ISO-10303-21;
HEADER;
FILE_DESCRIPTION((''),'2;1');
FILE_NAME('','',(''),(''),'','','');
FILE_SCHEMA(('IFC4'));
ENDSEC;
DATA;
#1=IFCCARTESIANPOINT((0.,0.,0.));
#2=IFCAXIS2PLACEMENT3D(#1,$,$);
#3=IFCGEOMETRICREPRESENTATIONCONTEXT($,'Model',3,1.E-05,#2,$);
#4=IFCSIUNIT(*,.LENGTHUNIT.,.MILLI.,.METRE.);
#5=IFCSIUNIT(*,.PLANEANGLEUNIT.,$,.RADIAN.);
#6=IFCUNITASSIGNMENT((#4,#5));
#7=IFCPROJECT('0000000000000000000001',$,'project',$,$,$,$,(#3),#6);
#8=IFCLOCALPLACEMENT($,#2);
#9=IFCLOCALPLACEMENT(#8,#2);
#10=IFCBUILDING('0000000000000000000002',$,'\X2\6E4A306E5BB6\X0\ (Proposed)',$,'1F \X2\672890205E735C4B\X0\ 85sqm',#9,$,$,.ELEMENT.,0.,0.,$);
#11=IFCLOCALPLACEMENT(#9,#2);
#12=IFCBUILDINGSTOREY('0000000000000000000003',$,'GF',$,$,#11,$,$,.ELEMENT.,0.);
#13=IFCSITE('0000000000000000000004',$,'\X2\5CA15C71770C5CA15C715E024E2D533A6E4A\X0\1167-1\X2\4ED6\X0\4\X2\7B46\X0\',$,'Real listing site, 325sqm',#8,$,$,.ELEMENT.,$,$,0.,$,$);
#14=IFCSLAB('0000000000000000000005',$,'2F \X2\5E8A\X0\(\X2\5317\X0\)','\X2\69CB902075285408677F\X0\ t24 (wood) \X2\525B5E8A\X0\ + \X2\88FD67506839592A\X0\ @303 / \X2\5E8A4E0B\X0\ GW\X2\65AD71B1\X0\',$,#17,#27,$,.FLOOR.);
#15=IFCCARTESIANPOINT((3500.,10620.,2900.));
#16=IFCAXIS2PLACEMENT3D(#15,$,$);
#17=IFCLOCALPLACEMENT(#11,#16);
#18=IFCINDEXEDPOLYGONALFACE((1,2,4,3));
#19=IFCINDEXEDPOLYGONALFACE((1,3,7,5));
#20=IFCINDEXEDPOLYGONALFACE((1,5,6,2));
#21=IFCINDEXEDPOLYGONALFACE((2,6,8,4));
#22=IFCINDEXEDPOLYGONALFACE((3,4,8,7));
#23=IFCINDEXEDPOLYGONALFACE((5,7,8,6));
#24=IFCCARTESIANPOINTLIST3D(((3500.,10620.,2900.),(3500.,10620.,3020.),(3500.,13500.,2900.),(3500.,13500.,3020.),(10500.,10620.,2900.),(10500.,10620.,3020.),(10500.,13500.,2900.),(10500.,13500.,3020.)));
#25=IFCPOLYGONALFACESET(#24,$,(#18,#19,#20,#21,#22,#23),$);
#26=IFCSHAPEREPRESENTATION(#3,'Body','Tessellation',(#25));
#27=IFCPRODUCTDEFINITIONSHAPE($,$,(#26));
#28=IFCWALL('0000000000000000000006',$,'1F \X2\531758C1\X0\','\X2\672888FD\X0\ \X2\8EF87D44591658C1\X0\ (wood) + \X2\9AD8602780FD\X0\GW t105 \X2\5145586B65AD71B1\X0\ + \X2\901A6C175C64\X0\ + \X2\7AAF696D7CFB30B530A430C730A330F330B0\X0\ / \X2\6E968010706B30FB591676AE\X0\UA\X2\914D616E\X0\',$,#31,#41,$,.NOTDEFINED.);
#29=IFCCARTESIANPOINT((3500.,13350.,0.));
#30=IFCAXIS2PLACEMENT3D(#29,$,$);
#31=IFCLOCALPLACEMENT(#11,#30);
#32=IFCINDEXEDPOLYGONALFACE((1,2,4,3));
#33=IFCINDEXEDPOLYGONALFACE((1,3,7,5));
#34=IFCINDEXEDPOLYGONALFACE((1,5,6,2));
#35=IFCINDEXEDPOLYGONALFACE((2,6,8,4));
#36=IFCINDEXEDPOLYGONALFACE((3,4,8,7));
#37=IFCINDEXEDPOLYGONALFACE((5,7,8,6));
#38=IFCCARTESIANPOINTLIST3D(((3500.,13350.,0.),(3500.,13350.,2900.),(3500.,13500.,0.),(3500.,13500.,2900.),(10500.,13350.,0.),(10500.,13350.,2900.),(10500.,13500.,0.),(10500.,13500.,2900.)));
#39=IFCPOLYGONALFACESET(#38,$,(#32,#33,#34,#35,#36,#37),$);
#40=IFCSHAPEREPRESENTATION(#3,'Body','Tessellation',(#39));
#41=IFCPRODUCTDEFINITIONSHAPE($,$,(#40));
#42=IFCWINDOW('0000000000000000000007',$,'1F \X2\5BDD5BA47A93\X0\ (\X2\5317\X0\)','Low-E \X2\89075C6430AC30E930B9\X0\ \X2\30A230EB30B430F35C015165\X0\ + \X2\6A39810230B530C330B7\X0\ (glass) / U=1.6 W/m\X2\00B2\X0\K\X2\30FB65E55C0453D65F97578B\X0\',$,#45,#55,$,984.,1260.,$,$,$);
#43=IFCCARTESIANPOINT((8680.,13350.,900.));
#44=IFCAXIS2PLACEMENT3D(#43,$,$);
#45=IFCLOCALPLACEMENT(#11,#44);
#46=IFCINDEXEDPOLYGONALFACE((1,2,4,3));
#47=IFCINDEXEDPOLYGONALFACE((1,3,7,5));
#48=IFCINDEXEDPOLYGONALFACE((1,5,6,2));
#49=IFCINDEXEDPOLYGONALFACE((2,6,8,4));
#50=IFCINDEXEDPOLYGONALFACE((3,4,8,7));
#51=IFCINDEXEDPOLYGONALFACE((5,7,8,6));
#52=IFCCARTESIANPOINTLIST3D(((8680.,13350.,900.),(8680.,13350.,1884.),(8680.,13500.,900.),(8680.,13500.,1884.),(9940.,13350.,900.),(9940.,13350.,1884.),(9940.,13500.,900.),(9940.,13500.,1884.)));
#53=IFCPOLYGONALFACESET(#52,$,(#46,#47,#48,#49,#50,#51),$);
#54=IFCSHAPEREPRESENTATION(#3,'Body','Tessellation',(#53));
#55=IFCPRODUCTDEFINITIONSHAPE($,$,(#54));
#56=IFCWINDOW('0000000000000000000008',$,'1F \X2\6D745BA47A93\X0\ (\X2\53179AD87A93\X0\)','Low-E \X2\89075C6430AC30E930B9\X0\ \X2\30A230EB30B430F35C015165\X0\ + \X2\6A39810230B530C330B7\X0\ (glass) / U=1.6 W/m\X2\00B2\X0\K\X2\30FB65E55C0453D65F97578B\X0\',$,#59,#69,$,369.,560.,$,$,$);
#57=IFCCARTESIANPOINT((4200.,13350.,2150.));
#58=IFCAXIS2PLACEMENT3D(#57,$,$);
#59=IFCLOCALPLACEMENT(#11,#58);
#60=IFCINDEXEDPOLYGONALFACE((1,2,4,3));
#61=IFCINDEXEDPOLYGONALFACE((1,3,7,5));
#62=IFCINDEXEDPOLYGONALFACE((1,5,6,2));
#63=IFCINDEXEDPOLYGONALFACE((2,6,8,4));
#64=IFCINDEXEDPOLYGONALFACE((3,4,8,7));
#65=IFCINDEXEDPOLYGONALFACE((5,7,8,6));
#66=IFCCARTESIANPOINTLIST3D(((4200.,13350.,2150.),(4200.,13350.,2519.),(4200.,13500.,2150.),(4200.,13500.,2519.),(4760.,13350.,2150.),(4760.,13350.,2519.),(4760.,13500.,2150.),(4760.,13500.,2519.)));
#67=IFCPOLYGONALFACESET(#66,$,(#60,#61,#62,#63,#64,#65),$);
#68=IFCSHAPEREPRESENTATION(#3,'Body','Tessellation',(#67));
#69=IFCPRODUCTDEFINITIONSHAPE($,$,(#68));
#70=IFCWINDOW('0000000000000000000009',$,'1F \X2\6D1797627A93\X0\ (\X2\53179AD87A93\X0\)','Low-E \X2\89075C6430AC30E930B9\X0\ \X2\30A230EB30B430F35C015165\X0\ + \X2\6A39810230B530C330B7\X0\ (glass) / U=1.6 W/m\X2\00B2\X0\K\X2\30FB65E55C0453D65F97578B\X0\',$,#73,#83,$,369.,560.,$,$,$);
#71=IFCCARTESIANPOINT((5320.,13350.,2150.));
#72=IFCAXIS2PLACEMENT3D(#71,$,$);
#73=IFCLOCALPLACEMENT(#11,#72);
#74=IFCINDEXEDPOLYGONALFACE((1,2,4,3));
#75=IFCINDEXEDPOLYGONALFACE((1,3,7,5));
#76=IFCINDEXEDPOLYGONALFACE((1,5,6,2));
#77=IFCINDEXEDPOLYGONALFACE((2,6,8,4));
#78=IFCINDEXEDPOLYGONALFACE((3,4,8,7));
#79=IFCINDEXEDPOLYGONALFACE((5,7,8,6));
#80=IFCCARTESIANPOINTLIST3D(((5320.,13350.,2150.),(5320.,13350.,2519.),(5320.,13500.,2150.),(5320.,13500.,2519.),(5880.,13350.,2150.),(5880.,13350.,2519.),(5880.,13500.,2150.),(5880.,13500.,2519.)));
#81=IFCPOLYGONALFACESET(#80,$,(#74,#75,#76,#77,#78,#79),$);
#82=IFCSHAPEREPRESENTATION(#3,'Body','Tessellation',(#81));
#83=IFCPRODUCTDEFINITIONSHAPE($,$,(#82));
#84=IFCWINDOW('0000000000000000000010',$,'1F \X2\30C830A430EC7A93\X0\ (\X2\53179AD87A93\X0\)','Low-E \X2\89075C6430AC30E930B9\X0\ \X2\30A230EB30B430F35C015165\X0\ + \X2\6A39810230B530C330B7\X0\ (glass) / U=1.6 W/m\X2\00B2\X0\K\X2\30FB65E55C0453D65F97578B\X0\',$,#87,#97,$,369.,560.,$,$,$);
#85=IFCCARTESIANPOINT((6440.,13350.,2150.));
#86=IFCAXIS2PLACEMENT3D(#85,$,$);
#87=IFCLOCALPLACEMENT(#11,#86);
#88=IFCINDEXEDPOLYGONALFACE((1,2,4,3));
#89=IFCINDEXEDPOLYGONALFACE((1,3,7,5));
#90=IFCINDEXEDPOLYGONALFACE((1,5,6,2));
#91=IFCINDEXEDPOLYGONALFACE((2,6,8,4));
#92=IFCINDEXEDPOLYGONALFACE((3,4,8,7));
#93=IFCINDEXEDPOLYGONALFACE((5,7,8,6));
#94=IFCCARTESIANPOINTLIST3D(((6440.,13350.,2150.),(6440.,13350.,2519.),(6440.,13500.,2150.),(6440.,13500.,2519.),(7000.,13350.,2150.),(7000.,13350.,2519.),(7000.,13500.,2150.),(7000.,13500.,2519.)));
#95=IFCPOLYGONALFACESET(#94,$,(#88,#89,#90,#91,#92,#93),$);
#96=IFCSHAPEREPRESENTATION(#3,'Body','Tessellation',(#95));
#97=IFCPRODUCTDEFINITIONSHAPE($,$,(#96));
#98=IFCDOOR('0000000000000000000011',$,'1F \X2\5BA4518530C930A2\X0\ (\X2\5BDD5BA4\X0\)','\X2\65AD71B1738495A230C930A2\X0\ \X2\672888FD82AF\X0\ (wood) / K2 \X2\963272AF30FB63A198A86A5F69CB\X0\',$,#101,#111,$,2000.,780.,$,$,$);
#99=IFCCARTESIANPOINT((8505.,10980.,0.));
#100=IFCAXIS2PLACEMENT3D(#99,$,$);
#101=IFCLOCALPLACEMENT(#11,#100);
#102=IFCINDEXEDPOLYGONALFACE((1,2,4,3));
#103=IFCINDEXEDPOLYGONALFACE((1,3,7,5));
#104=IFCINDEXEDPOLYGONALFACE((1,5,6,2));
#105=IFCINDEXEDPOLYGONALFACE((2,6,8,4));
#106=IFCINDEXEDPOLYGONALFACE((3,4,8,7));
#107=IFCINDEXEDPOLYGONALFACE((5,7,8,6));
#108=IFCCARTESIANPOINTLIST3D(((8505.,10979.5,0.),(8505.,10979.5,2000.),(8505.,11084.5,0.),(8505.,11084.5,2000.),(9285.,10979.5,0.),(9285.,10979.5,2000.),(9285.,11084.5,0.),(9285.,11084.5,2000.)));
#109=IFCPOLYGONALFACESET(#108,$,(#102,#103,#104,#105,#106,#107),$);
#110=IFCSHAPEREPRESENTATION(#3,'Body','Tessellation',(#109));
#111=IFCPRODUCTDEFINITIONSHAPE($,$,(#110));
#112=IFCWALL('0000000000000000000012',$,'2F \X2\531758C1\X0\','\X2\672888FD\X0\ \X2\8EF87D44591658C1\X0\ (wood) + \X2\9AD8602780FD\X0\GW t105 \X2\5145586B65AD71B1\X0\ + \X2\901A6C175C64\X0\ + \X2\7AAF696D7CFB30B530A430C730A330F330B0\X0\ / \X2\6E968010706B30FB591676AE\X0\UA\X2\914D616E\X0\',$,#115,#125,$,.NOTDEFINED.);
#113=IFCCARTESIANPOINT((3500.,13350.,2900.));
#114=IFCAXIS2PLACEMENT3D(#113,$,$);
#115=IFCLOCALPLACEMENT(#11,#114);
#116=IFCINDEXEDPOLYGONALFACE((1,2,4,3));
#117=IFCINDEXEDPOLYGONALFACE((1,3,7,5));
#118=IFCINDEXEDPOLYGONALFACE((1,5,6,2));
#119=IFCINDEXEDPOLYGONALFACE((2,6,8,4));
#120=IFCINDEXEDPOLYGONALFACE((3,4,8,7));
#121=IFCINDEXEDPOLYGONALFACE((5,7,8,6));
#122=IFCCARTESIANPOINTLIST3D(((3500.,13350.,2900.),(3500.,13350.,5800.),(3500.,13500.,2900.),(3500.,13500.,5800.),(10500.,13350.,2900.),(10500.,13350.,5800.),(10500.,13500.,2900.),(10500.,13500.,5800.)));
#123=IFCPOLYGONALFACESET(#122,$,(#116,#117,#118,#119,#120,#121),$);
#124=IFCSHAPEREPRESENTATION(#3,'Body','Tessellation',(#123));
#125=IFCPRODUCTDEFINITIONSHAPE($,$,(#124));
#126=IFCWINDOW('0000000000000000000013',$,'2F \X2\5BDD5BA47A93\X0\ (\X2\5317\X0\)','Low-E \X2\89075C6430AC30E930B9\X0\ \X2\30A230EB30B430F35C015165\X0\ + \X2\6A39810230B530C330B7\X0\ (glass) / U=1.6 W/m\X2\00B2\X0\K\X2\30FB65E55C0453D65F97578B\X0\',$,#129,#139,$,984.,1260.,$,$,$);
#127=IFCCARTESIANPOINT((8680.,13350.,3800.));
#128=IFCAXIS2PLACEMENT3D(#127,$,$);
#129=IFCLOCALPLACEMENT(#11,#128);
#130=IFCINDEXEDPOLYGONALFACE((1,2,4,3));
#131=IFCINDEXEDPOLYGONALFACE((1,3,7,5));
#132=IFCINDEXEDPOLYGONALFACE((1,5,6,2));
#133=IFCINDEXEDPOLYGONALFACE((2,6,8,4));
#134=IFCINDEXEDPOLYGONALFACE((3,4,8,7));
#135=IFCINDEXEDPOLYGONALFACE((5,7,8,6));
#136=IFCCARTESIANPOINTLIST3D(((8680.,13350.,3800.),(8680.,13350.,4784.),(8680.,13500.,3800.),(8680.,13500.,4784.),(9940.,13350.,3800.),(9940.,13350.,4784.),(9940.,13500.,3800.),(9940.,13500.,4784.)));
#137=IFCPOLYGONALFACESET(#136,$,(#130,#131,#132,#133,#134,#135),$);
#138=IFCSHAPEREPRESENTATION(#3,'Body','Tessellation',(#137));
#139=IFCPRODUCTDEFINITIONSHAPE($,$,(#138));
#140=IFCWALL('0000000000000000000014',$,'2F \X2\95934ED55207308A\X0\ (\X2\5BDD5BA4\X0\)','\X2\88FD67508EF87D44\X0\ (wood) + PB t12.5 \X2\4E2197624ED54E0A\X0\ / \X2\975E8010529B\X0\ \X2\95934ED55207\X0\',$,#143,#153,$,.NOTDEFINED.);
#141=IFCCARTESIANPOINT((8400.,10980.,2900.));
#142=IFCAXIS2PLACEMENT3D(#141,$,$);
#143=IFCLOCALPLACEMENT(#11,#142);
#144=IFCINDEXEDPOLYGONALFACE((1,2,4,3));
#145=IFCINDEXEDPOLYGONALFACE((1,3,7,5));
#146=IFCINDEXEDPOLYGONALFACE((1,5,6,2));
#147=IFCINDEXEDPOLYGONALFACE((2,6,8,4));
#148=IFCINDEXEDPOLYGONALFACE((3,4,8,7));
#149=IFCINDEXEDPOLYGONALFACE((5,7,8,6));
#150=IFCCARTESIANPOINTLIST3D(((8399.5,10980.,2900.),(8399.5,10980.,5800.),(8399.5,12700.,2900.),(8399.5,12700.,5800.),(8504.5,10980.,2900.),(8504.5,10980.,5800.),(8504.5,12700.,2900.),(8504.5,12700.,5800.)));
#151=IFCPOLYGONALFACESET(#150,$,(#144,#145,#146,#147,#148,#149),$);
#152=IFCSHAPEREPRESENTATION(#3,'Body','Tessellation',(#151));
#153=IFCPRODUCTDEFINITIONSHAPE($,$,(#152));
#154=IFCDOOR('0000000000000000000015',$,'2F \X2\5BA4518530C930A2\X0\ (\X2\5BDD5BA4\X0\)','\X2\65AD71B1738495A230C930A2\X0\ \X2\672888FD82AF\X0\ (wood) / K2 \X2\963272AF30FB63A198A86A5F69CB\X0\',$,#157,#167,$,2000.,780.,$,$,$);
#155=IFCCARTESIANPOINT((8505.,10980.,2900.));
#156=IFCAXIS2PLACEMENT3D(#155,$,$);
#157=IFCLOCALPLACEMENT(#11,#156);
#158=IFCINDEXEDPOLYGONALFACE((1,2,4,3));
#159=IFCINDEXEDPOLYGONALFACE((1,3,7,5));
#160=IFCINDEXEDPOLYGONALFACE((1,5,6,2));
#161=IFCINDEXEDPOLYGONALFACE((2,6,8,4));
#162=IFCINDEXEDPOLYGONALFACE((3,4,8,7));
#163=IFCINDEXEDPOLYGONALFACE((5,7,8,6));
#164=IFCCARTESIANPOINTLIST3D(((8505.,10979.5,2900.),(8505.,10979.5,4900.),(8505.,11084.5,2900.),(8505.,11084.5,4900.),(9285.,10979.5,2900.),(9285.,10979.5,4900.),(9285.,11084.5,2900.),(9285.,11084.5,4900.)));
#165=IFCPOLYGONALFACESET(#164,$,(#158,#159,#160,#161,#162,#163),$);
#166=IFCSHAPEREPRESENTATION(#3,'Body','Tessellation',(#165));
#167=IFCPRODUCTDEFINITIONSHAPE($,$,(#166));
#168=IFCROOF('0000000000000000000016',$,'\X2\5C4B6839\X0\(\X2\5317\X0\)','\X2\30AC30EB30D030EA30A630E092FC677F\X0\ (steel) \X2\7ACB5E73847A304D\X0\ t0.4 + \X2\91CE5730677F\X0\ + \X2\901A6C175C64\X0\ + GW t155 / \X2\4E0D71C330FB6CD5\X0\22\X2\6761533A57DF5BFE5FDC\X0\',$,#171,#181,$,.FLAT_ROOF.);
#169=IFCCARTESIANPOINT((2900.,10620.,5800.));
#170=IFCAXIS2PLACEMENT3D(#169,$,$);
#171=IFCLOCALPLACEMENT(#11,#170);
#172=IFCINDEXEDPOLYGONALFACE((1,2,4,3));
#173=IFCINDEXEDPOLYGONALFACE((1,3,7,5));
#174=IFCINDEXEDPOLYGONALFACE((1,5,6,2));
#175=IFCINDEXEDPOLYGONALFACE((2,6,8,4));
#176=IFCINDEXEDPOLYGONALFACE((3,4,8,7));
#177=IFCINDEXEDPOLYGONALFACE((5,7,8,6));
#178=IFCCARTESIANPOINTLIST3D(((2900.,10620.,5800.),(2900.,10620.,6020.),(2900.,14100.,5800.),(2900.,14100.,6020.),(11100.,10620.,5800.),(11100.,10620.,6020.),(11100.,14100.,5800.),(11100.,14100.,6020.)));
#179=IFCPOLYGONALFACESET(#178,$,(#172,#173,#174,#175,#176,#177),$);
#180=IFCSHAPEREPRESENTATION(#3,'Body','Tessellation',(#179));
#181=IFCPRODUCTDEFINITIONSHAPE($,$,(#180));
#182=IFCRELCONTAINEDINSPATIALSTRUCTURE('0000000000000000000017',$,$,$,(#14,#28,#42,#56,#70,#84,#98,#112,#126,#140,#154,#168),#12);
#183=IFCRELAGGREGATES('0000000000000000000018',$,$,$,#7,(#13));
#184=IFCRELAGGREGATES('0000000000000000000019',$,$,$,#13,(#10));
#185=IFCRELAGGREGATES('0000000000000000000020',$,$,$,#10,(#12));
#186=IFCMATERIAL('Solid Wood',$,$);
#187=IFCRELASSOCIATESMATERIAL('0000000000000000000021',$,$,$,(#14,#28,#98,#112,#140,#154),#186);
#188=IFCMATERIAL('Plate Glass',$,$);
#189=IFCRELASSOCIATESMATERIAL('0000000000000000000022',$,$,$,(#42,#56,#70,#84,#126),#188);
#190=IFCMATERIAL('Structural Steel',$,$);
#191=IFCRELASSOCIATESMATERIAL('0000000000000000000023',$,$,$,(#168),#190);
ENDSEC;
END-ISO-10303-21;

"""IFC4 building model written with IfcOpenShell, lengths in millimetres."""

from ifc_helpers import new_model, si_unit, frame, frame_2d, origin, place, context, project, spatial, rectangle, extrude, material, element, fill, save


model = new_model("IFC4")

# Units and contexts
model_context = context("Model", 3, precision=1e-05, world=origin())
ifc_project = project(units=[si_unit("LENGTHUNIT", "METRE", prefix="MILLI"), si_unit("PLANEANGLEUNIT", "RADIAN")], contexts=[model_context])

# Site, building, storey
site_placement = place(None, origin())
site = spatial("IfcSite", under=ifc_project, at=site_placement, Name="岡山県岡山市中区湊1167-1他4筆", ObjectType="Real listing site, 325sqm", CompositionType="ELEMENT", RefElevation=0.0)
building_placement = place(site_placement, origin())
building = spatial("IfcBuilding", under=site, at=building_placement, Name="湊の家 (Proposed)", ObjectType="1F 木造平屋 85sqm", CompositionType="ELEMENT", ElevationOfRefHeight=0.0, ElevationOfTerrain=0.0)
storey_placement = place(building_placement, origin())
storey = spatial("IfcBuildingStorey", under=building, at=storey_placement, Name="GF", CompositionType="ELEMENT", Elevation=0.0)

# Slab
ifc_material_1 = material(Name="Solid Wood")
slab_placement = place(storey_placement, frame((3500.0, 10620.0, 2900.0)))
element("IfcSlab", 1, at=slab_placement, inside=storey, material=ifc_material_1, Name="2F 床(北)", Description="構造用合板 t24 (wood) 剛床 + 製材根太 @303 / 床下 GW断熱", PredefinedType="FLOOR", context=model_context, shape_type="SweptSolid", body=[
    extrude(rectangle(XDim=7000.0, YDim=2880.0, at=frame_2d((3500.0, 1440.0))), frame((3500.0, 10620.0, 2900.0)), (0.0, 0.0, 1.0), 120.0),
])

# Wall, openings, windows
wall_1_placement = place(storey_placement, frame((3500.0, 13350.0, 0.0)))
wall_1 = element("IfcWall", 2, at=wall_1_placement, inside=storey, material=ifc_material_1, Name="1F 北壁", Description="木製 軸組外壁 (wood) + 高性能GW t105 充填断熱 + 通気層 + 窯業系サイディング / 準耐火・外皮UA配慮", PredefinedType="NOTDEFINED", context=model_context, shape_type="SweptSolid", body=[
    extrude(rectangle(XDim=7000.0, YDim=150.0, at=frame_2d((3500.0, 75.0))), frame((3500.0, 13350.0, 0.0)), (0.0, 0.0, 1.0), 2900.0),
])
opening_1_placement = place(storey_placement, frame((8680.0, 13350.0, 900.0)))
opening_1 = element("IfcOpeningElement", 3, at=opening_1_placement, cuts=wall_1, PredefinedType="NOTDEFINED", context=model_context, shape_type="SweptSolid", body=[
    extrude(rectangle(XDim=1260.0, YDim=150.0, at=frame_2d((630.0, 75.0))), frame((8680.0, 13350.0, 900.0)), (0.0, 0.0, 1.0), 984.0),
])
opening_2_placement = place(storey_placement, frame((4200.0, 13350.0, 2150.0)))
opening_2 = element("IfcOpeningElement", 4, at=opening_2_placement, cuts=wall_1, PredefinedType="NOTDEFINED", context=model_context, shape_type="SweptSolid", body=[
    extrude(rectangle(XDim=560.0, YDim=150.0, at=frame_2d((280.0, 75.0))), frame((4200.0, 13350.0, 2150.0)), (0.0, 0.0, 1.0), 369.0),
])
opening_3_placement = place(storey_placement, frame((5320.0, 13350.0, 2150.0)))
opening_3 = element("IfcOpeningElement", 5, at=opening_3_placement, cuts=wall_1, PredefinedType="NOTDEFINED", context=model_context, shape_type="SweptSolid", body=[
    extrude(rectangle(XDim=560.0, YDim=150.0, at=frame_2d((280.0, 75.0))), frame((5320.0, 13350.0, 2150.0)), (0.0, 0.0, 1.0), 369.0),
])
opening_4_placement = place(storey_placement, frame((6440.0, 13350.0, 2150.0)))
opening_4 = element("IfcOpeningElement", 6, at=opening_4_placement, cuts=wall_1, PredefinedType="NOTDEFINED", context=model_context, shape_type="SweptSolid", body=[
    extrude(rectangle(XDim=560.0, YDim=150.0, at=frame_2d((280.0, 75.0))), frame((6440.0, 13350.0, 2150.0)), (0.0, 0.0, 1.0), 369.0),
])
ifc_material_2 = material(Name="Plate Glass")
window_1_placement = place(storey_placement, frame((8680.0, 13350.0, 900.0)))
window_1 = element("IfcWindow", 7, at=window_1_placement, inside=storey, material=ifc_material_2, Name="1F 寝室窓 (北)", Description="Low-E 複層ガラス アルゴン封入 + 樹脂サッシ (glass) / U=1.6 W/m²K・日射取得型", OverallHeight=984.0, OverallWidth=1260.0, context=model_context, shape_type="SweptSolid", body=[
    extrude(rectangle(XDim=1260.0, YDim=150.0, at=frame_2d((630.0, 75.0))), frame((8680.0, 13350.0, 900.0)), (0.0, 0.0, 1.0), 984.0),
])
fill(opening_1, window_1)
window_2_placement = place(storey_placement, frame((4200.0, 13350.0, 2150.0)))
window_2 = element("IfcWindow", 8, at=window_2_placement, inside=storey, material=ifc_material_2, Name="1F 浴室窓 (北高窓)", Description="Low-E 複層ガラス アルゴン封入 + 樹脂サッシ (glass) / U=1.6 W/m²K・日射取得型", OverallHeight=369.0, OverallWidth=560.0, context=model_context, shape_type="SweptSolid", body=[
    extrude(rectangle(XDim=560.0, YDim=150.0, at=frame_2d((280.0, 75.0))), frame((4200.0, 13350.0, 2150.0)), (0.0, 0.0, 1.0), 369.0),
])
fill(opening_2, window_2)
window_3_placement = place(storey_placement, frame((5320.0, 13350.0, 2150.0)))
window_3 = element("IfcWindow", 9, at=window_3_placement, inside=storey, material=ifc_material_2, Name="1F 洗面窓 (北高窓)", Description="Low-E 複層ガラス アルゴン封入 + 樹脂サッシ (glass) / U=1.6 W/m²K・日射取得型", OverallHeight=369.0, OverallWidth=560.0, context=model_context, shape_type="SweptSolid", body=[
    extrude(rectangle(XDim=560.0, YDim=150.0, at=frame_2d((280.0, 75.0))), frame((5320.0, 13350.0, 2150.0)), (0.0, 0.0, 1.0), 369.0),
])
fill(opening_3, window_3)
window_4_placement = place(storey_placement, frame((6440.0, 13350.0, 2150.0)))
window_4 = element("IfcWindow", 10, at=window_4_placement, inside=storey, material=ifc_material_2, Name="1F トイレ窓 (北高窓)", Description="Low-E 複層ガラス アルゴン封入 + 樹脂サッシ (glass) / U=1.6 W/m²K・日射取得型", OverallHeight=369.0, OverallWidth=560.0, context=model_context, shape_type="SweptSolid", body=[
    extrude(rectangle(XDim=560.0, YDim=150.0, at=frame_2d((280.0, 75.0))), frame((6440.0, 13350.0, 2150.0)), (0.0, 0.0, 1.0), 369.0),
])
fill(opening_4, window_4)

# Door
door_1_placement = place(storey_placement, frame((8505.0, 10980.0, 0.0)))
element("IfcDoor", 11, at=door_1_placement, inside=storey, material=ifc_material_1, Name="1F 室内ドア (寝室)", Description="断熱玄関ドア 木製芯 (wood) / K2 防犯・採風機構", OverallHeight=2000.0, OverallWidth=780.0, context=model_context, shape_type="SweptSolid", body=[
    extrude(rectangle(XDim=780.0, YDim=105.0, at=frame_2d((390.0, 52.0))), frame((8505.0, 10980.0, 0.0)), (0.0, 0.0, 1.0), 2000.0),
])

# Wall, opening, window
wall_2_placement = place(storey_placement, frame((3500.0, 13350.0, 2900.0)))
wall_2 = element("IfcWall", 12, at=wall_2_placement, inside=storey, material=ifc_material_1, Name="2F 北壁", Description="木製 軸組外壁 (wood) + 高性能GW t105 充填断熱 + 通気層 + 窯業系サイディング / 準耐火・外皮UA配慮", PredefinedType="NOTDEFINED", context=model_context, shape_type="SweptSolid", body=[
    extrude(rectangle(XDim=7000.0, YDim=150.0, at=frame_2d((3500.0, 75.0))), frame((3500.0, 13350.0, 2900.0)), (0.0, 0.0, 1.0), 2900.0),
])
opening_5_placement = place(storey_placement, frame((8680.0, 13350.0, 3800.0)))
opening_5 = element("IfcOpeningElement", 13, at=opening_5_placement, cuts=wall_2, PredefinedType="NOTDEFINED", context=model_context, shape_type="SweptSolid", body=[
    extrude(rectangle(XDim=1260.0, YDim=150.0, at=frame_2d((630.0, 75.0))), frame((8680.0, 13350.0, 3800.0)), (0.0, 0.0, 1.0), 984.0),
])
window_5_placement = place(storey_placement, frame((8680.0, 13350.0, 3800.0)))
window_5 = element("IfcWindow", 14, at=window_5_placement, inside=storey, material=ifc_material_2, Name="2F 寝室窓 (北)", Description="Low-E 複層ガラス アルゴン封入 + 樹脂サッシ (glass) / U=1.6 W/m²K・日射取得型", OverallHeight=984.0, OverallWidth=1260.0, context=model_context, shape_type="SweptSolid", body=[
    extrude(rectangle(XDim=1260.0, YDim=150.0, at=frame_2d((630.0, 75.0))), frame((8680.0, 13350.0, 3800.0)), (0.0, 0.0, 1.0), 984.0),
])
fill(opening_5, window_5)

# Wall
wall_3_placement = place(storey_placement, frame((8400.0, 10980.0, 2900.0)))
element("IfcWall", 15, at=wall_3_placement, inside=storey, material=ifc_material_1, Name="2F 間仕切り (寝室)", Description="製材軸組 (wood) + PB t12.5 両面仕上 / 非耐力 間仕切", PredefinedType="NOTDEFINED", context=model_context, shape_type="SweptSolid", body=[
    extrude(rectangle(XDim=105.0, YDim=1720.0, at=frame_2d((52.0, 860.0))), frame((8400.0, 10980.0, 2900.0)), (0.0, 0.0, 1.0), 2900.0),
])

# Door
door_2_placement = place(storey_placement, frame((8505.0, 10980.0, 2900.0)))
element("IfcDoor", 16, at=door_2_placement, inside=storey, material=ifc_material_1, Name="2F 室内ドア (寝室)", Description="断熱玄関ドア 木製芯 (wood) / K2 防犯・採風機構", OverallHeight=2000.0, OverallWidth=780.0, context=model_context, shape_type="SweptSolid", body=[
    extrude(rectangle(XDim=780.0, YDim=105.0, at=frame_2d((390.0, 52.0))), frame((8505.0, 10980.0, 2900.0)), (0.0, 0.0, 1.0), 2000.0),
])

# Roof
ifc_material_3 = material(Name="Structural Steel")
roof_placement = place(storey_placement, frame((2900.0, 10620.0, 5800.0)))
element("IfcRoof", 17, at=roof_placement, inside=storey, material=ifc_material_3, Name="屋根(北)", Description="ガルバリウム鋼板 (steel) 立平葺き t0.4 + 野地板 + 通気層 + GW t155 / 不燃・法22条区域対応", PredefinedType="FLAT_ROOF", context=model_context, shape_type="SweptSolid", body=[
    extrude(rectangle(XDim=8200.0, YDim=3480.0, at=frame_2d((4100.0, 1740.0))), frame((2900.0, 10620.0, 5800.0)), (0.0, 0.0, 1.0), 220.0),
])

save(model, "model.ifc")
